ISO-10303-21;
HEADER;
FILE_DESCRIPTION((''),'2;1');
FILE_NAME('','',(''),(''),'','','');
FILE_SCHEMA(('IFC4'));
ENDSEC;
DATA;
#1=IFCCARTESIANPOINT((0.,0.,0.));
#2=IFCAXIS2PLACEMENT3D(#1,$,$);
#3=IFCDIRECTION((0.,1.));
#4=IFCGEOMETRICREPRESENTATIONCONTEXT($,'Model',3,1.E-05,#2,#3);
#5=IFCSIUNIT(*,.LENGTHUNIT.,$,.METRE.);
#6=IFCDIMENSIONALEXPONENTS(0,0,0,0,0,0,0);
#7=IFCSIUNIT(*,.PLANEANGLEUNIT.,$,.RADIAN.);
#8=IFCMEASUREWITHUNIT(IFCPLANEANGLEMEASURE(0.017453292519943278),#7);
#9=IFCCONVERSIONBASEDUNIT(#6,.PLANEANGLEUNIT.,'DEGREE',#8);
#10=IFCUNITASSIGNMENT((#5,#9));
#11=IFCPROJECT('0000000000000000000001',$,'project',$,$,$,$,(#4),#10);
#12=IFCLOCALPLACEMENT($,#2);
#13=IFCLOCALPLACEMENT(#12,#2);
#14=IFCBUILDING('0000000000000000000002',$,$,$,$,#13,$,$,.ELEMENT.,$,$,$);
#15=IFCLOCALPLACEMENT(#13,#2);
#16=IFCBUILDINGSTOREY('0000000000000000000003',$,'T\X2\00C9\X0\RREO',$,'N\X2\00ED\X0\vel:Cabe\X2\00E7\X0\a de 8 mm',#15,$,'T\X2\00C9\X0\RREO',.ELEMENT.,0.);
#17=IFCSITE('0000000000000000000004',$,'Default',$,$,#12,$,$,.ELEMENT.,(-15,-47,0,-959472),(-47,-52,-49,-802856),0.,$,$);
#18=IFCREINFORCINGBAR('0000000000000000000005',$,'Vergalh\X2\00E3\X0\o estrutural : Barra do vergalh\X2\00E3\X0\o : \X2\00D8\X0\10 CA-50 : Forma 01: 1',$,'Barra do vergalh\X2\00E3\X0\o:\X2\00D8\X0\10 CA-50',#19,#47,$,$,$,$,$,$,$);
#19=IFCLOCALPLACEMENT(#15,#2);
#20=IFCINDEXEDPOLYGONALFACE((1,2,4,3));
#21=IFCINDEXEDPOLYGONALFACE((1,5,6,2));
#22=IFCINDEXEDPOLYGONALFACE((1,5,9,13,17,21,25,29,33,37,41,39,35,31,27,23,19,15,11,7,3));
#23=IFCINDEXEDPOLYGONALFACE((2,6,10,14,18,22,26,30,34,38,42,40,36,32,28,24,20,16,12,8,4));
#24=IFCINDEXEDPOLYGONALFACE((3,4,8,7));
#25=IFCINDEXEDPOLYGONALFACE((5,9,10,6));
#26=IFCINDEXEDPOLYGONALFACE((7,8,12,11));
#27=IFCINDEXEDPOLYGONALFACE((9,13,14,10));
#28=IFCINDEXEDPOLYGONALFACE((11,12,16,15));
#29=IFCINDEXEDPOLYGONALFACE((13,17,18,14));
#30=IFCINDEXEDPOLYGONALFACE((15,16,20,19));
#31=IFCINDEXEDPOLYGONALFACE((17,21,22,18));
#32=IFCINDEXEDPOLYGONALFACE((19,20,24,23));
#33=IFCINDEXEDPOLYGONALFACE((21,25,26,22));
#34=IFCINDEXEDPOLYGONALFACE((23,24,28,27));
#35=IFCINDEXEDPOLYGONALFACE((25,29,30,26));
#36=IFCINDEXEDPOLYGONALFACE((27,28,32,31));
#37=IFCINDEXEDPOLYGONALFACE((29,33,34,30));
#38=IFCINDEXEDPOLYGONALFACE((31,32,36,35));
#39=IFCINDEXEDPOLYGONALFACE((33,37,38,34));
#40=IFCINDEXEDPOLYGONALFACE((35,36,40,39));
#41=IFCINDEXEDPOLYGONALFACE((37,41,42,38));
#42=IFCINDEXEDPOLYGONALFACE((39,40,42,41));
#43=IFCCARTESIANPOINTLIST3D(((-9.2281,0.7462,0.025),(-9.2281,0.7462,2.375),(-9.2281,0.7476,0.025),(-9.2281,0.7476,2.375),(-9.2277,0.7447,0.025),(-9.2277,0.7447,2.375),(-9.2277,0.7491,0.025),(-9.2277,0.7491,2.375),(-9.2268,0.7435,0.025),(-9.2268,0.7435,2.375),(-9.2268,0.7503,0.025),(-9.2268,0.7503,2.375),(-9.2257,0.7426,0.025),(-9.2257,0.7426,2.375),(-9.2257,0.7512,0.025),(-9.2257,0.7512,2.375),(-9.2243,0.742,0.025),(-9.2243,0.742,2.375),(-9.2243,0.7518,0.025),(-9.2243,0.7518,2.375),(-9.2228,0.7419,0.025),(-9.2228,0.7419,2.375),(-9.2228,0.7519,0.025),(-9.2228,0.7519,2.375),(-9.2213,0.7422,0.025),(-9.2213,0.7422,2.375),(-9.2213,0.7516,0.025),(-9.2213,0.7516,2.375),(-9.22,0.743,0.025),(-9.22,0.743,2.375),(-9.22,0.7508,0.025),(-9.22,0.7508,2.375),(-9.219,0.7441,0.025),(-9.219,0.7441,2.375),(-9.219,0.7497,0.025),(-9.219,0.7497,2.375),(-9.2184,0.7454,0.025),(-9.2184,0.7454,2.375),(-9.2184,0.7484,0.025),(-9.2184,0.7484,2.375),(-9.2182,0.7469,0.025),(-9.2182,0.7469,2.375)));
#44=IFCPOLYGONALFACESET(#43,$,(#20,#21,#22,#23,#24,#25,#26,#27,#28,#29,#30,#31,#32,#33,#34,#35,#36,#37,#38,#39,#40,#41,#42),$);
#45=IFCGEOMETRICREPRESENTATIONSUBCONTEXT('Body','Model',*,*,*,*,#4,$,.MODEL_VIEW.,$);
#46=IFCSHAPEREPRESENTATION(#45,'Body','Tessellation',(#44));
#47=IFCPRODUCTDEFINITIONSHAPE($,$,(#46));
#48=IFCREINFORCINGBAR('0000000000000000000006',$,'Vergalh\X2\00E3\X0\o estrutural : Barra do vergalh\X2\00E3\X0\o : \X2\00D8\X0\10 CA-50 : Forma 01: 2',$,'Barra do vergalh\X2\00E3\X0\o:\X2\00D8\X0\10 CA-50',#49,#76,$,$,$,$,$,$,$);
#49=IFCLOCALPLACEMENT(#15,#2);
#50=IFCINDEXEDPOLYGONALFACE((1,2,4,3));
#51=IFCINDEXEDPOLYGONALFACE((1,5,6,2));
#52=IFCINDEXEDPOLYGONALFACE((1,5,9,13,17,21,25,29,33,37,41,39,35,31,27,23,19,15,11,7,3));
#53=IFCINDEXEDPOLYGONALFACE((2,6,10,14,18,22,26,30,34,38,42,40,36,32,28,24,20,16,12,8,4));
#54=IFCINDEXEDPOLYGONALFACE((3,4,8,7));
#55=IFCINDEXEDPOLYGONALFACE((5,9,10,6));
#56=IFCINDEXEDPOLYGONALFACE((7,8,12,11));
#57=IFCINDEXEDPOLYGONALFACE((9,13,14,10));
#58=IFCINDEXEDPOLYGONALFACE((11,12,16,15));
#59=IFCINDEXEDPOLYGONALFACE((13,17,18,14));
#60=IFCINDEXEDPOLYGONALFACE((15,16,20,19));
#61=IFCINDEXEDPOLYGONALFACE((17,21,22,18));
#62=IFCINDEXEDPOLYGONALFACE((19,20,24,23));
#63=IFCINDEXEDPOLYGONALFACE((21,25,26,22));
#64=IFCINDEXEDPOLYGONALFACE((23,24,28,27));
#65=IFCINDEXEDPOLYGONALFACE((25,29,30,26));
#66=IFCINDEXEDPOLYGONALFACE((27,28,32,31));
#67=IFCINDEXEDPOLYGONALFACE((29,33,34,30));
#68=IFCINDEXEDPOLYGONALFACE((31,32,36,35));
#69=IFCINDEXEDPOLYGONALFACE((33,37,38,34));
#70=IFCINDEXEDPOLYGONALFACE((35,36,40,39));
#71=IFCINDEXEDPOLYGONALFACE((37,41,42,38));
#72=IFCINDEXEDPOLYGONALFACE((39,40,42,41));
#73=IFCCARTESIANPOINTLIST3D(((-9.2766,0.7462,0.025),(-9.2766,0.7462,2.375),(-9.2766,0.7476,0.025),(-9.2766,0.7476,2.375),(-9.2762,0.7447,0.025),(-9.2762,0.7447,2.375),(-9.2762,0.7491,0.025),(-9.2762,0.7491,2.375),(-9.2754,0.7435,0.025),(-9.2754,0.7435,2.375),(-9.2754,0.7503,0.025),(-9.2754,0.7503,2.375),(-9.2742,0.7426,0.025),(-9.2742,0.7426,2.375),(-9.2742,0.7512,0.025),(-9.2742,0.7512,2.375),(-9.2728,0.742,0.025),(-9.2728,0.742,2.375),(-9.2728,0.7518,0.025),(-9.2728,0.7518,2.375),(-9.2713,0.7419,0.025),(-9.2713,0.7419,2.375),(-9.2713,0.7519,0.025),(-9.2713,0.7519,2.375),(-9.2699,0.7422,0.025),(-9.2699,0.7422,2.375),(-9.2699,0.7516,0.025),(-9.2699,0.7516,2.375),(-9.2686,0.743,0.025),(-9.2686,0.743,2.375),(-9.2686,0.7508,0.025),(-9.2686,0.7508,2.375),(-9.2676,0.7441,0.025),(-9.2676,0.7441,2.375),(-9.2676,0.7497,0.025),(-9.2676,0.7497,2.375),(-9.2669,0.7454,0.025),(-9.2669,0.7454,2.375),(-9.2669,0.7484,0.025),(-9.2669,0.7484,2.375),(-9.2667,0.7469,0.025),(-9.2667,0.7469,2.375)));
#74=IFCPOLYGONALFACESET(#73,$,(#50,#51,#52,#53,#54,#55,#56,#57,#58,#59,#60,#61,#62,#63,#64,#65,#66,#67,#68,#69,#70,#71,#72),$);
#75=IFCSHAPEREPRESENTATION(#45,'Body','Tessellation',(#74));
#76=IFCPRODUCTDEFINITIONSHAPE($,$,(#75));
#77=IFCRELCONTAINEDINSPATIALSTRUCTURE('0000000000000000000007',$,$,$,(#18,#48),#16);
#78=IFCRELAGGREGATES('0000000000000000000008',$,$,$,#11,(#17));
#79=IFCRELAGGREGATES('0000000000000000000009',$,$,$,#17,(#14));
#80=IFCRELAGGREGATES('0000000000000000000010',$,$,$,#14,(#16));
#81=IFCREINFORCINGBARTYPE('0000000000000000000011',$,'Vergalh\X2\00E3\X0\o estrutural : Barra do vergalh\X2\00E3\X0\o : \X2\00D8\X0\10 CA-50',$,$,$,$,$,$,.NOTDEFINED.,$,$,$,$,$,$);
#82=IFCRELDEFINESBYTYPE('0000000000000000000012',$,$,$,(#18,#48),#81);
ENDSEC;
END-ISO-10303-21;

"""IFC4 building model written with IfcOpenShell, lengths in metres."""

from ifc_helpers import new_model, entity, si_unit, converted_unit, direction, origin, place, context, subcontext, project, spatial, type_object, element, save


model = new_model("IFC4")

# Units and contexts
model_context = context("Model", 3, precision=1e-05, world=origin(), true_north=direction((0.0, 1.0)))
body_context = subcontext(model_context, "Body", "Model", "MODEL_VIEW")
ifc_project = project(units=[si_unit("LENGTHUNIT", "METRE"), converted_unit("PLANEANGLEUNIT", "DEGREE", entity("IfcPlaneAngleMeasure", 0.017453292519943278), si_unit("PLANEANGLEUNIT", "RADIAN"), dimensions=[0, 0, 0, 0, 0, 0, 0])], contexts=[model_context])

# Site, building, storey
site_placement = place(None, origin())
site = spatial("IfcSite", under=ifc_project, at=site_placement, Name="Default", CompositionType="ELEMENT", RefLatitude=(-15, -47, 0, -959472), RefLongitude=(-47, -52, -49, -802856), RefElevation=0.0)
building_placement = place(site_placement, origin())
building = spatial("IfcBuilding", under=site, at=building_placement, CompositionType="ELEMENT")
storey_placement = place(building_placement, origin())
storey = spatial("IfcBuildingStorey", under=building, at=storey_placement, Name="TÉRREO", ObjectType="Nível:Cabeça de 8 mm", LongName="TÉRREO", CompositionType="ELEMENT", Elevation=0.0)

# Reinforcing bars
reinforcing_bar_type_1 = type_object("IfcReinforcingBarType", Name="Vergalhão estrutural : Barra do vergalhão : Ø10 CA-50", PredefinedType="NOTDEFINED")
reinforcing_bar_1_placement = place(storey_placement, origin())
element("IfcReinforcingBar", 1, at=reinforcing_bar_1_placement, inside=storey, type_object=reinforcing_bar_type_1, Name="Vergalhão estrutural : Barra do vergalhão : Ø10 CA-50 : Forma 01: 1", ObjectType="Barra do vergalhão:Ø10 CA-50", context=body_context, shape_type="AdvancedSweptSolid", body=[
    entity("IfcSweptDiskSolid", entity("IfcIndexedPolyCurve", entity("IfcCartesianPointList3D", [[-9.2232, 0.7469, 0.025], [-9.2232, 0.7469, 2.375]]), None, False), 0.005, None, 0.0, 1.0),
])
reinforcing_bar_2_placement = place(storey_placement, origin())
element("IfcReinforcingBar", 2, at=reinforcing_bar_2_placement, inside=storey, type_object=reinforcing_bar_type_1, Name="Vergalhão estrutural : Barra do vergalhão : Ø10 CA-50 : Forma 01: 2", ObjectType="Barra do vergalhão:Ø10 CA-50", context=body_context, shape_type="AdvancedSweptSolid", body=[
    entity("IfcSweptDiskSolid", entity("IfcIndexedPolyCurve", entity("IfcCartesianPointList3D", [[-9.2717, 0.7469, 0.025], [-9.2717, 0.7469, 2.375]]), None, False), 0.005, None, 0.0, 1.0),
])

save(model, "model.ifc")
